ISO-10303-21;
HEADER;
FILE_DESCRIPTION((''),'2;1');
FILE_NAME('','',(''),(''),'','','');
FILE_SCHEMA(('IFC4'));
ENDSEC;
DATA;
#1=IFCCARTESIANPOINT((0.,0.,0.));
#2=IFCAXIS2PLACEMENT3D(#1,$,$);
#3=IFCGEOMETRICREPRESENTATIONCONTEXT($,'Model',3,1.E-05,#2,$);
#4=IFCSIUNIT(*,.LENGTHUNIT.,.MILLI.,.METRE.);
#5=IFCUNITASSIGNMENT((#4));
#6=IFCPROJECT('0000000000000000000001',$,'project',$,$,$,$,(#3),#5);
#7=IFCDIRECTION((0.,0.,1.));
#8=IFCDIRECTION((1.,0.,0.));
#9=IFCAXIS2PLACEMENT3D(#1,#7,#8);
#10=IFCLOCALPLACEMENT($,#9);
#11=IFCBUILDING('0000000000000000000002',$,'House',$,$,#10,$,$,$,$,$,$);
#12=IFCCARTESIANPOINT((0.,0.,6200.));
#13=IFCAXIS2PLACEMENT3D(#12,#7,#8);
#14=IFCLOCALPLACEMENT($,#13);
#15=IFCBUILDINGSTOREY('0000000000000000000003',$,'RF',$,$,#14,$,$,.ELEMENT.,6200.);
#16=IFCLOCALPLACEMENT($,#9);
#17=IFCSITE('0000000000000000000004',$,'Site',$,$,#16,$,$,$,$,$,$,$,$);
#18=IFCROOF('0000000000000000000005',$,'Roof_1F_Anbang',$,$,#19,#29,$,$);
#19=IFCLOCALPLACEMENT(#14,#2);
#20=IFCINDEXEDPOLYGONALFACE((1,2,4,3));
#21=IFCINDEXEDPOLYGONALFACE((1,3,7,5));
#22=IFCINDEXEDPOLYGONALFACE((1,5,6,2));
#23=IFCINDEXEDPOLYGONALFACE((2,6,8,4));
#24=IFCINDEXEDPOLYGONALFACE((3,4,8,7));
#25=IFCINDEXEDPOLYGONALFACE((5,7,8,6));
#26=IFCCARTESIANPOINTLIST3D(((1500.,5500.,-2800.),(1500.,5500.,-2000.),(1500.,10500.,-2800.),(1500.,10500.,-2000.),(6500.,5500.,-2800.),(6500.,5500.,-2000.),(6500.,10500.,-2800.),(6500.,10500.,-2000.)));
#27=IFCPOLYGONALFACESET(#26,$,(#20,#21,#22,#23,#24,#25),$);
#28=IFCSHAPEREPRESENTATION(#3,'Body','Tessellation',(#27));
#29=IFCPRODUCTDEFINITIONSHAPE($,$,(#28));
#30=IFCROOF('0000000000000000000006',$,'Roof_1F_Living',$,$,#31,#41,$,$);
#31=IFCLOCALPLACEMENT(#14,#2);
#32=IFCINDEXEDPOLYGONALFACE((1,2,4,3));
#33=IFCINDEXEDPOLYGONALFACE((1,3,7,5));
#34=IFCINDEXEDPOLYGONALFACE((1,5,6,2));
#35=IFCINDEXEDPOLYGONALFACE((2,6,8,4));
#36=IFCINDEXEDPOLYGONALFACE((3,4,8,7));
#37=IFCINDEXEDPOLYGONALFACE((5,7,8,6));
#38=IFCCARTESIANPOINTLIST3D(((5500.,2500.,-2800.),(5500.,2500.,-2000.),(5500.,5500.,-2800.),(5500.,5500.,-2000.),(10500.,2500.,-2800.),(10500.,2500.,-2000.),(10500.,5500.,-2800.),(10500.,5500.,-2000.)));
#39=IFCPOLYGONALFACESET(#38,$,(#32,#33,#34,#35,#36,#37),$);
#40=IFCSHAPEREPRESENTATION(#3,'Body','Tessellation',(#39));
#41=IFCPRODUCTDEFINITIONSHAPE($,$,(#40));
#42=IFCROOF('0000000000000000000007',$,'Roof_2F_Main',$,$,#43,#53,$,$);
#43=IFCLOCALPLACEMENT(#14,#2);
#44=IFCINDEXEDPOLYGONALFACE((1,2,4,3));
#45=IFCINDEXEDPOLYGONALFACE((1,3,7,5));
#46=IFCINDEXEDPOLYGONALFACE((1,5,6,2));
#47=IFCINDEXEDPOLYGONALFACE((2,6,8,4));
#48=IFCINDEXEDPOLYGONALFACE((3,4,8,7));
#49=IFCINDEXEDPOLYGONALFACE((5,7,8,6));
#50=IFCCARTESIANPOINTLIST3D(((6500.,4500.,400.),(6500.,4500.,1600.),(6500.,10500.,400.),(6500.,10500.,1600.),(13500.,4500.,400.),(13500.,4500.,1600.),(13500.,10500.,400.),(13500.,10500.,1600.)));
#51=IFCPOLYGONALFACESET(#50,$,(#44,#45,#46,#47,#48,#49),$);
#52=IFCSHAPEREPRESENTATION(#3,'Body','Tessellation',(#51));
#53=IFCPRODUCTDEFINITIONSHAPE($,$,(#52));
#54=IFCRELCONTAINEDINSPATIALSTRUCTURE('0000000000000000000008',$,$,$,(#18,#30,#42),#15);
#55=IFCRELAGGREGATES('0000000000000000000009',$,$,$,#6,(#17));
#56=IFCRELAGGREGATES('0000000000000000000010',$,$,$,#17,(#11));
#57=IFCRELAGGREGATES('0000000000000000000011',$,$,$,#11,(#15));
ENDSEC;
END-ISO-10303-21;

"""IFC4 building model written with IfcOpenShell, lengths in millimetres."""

from ifc_helpers import new_model, si_unit, frame, origin, origin_with_axes, place, context, project, spatial, rectangle, extrude, element, save


model = new_model("IFC4")

# Units and contexts
model_context = context("Model", 3, precision=1e-05, world=origin())
ifc_project = project(units=[si_unit("LENGTHUNIT", "METRE", prefix="MILLI")], contexts=[model_context])

# Site, building, storey
site_placement = place(None, origin_with_axes())
site = spatial("IfcSite", under=ifc_project, at=site_placement, Name="Site")
building_placement = place(None, origin_with_axes())
building = spatial("IfcBuilding", under=site, at=building_placement, Name="House")
storey_placement = place(None, frame((0.0, 0.0, 6200.0), z_axis=(0.0, 0.0, 1.0), x_axis=(1.0, 0.0, 0.0)))
storey = spatial("IfcBuildingStorey", under=building, at=storey_placement, Name="RF", CompositionType="ELEMENT", Elevation=6200.0)

# Roofs
roof_1_placement = place(None, frame((1500.0, 5500.0, 3400.0), z_axis=(0.0, 0.0, 1.0), x_axis=(1.0, 0.0, 0.0)))
element("IfcRoof", 1, at=roof_1_placement, inside=storey, Name="Roof_1F_Anbang", context=model_context, shape_type="SweptSolid", body=[
    extrude(rectangle(XDim=5000.0, YDim=5000.0), frame((2500.0, 2500.0, 0.0)), (0.0, 0.0, 1.0), 800.0),
])
roof_2_placement = place(None, frame((5500.0, 2500.0, 3400.0), z_axis=(0.0, 0.0, 1.0), x_axis=(1.0, 0.0, 0.0)))
element("IfcRoof", 2, at=roof_2_placement, inside=storey, Name="Roof_1F_Living", context=model_context, shape_type="SweptSolid", body=[
    extrude(rectangle(XDim=5000.0, YDim=3000.0), frame((2500.0, 1500.0, 0.0)), (0.0, 0.0, 1.0), 800.0),
])
roof_3_placement = place(None, frame((6500.0, 4500.0, 6600.0), z_axis=(0.0, 0.0, 1.0), x_axis=(1.0, 0.0, 0.0)))
element("IfcRoof", 3, at=roof_3_placement, inside=storey, Name="Roof_2F_Main", context=model_context, shape_type="SweptSolid", body=[
    extrude(rectangle(XDim=7000.0, YDim=6000.0), frame((3500.0, 3000.0, 0.0)), (0.0, 0.0, 1.0), 1200.0),
])

save(model, "model.ifc")
